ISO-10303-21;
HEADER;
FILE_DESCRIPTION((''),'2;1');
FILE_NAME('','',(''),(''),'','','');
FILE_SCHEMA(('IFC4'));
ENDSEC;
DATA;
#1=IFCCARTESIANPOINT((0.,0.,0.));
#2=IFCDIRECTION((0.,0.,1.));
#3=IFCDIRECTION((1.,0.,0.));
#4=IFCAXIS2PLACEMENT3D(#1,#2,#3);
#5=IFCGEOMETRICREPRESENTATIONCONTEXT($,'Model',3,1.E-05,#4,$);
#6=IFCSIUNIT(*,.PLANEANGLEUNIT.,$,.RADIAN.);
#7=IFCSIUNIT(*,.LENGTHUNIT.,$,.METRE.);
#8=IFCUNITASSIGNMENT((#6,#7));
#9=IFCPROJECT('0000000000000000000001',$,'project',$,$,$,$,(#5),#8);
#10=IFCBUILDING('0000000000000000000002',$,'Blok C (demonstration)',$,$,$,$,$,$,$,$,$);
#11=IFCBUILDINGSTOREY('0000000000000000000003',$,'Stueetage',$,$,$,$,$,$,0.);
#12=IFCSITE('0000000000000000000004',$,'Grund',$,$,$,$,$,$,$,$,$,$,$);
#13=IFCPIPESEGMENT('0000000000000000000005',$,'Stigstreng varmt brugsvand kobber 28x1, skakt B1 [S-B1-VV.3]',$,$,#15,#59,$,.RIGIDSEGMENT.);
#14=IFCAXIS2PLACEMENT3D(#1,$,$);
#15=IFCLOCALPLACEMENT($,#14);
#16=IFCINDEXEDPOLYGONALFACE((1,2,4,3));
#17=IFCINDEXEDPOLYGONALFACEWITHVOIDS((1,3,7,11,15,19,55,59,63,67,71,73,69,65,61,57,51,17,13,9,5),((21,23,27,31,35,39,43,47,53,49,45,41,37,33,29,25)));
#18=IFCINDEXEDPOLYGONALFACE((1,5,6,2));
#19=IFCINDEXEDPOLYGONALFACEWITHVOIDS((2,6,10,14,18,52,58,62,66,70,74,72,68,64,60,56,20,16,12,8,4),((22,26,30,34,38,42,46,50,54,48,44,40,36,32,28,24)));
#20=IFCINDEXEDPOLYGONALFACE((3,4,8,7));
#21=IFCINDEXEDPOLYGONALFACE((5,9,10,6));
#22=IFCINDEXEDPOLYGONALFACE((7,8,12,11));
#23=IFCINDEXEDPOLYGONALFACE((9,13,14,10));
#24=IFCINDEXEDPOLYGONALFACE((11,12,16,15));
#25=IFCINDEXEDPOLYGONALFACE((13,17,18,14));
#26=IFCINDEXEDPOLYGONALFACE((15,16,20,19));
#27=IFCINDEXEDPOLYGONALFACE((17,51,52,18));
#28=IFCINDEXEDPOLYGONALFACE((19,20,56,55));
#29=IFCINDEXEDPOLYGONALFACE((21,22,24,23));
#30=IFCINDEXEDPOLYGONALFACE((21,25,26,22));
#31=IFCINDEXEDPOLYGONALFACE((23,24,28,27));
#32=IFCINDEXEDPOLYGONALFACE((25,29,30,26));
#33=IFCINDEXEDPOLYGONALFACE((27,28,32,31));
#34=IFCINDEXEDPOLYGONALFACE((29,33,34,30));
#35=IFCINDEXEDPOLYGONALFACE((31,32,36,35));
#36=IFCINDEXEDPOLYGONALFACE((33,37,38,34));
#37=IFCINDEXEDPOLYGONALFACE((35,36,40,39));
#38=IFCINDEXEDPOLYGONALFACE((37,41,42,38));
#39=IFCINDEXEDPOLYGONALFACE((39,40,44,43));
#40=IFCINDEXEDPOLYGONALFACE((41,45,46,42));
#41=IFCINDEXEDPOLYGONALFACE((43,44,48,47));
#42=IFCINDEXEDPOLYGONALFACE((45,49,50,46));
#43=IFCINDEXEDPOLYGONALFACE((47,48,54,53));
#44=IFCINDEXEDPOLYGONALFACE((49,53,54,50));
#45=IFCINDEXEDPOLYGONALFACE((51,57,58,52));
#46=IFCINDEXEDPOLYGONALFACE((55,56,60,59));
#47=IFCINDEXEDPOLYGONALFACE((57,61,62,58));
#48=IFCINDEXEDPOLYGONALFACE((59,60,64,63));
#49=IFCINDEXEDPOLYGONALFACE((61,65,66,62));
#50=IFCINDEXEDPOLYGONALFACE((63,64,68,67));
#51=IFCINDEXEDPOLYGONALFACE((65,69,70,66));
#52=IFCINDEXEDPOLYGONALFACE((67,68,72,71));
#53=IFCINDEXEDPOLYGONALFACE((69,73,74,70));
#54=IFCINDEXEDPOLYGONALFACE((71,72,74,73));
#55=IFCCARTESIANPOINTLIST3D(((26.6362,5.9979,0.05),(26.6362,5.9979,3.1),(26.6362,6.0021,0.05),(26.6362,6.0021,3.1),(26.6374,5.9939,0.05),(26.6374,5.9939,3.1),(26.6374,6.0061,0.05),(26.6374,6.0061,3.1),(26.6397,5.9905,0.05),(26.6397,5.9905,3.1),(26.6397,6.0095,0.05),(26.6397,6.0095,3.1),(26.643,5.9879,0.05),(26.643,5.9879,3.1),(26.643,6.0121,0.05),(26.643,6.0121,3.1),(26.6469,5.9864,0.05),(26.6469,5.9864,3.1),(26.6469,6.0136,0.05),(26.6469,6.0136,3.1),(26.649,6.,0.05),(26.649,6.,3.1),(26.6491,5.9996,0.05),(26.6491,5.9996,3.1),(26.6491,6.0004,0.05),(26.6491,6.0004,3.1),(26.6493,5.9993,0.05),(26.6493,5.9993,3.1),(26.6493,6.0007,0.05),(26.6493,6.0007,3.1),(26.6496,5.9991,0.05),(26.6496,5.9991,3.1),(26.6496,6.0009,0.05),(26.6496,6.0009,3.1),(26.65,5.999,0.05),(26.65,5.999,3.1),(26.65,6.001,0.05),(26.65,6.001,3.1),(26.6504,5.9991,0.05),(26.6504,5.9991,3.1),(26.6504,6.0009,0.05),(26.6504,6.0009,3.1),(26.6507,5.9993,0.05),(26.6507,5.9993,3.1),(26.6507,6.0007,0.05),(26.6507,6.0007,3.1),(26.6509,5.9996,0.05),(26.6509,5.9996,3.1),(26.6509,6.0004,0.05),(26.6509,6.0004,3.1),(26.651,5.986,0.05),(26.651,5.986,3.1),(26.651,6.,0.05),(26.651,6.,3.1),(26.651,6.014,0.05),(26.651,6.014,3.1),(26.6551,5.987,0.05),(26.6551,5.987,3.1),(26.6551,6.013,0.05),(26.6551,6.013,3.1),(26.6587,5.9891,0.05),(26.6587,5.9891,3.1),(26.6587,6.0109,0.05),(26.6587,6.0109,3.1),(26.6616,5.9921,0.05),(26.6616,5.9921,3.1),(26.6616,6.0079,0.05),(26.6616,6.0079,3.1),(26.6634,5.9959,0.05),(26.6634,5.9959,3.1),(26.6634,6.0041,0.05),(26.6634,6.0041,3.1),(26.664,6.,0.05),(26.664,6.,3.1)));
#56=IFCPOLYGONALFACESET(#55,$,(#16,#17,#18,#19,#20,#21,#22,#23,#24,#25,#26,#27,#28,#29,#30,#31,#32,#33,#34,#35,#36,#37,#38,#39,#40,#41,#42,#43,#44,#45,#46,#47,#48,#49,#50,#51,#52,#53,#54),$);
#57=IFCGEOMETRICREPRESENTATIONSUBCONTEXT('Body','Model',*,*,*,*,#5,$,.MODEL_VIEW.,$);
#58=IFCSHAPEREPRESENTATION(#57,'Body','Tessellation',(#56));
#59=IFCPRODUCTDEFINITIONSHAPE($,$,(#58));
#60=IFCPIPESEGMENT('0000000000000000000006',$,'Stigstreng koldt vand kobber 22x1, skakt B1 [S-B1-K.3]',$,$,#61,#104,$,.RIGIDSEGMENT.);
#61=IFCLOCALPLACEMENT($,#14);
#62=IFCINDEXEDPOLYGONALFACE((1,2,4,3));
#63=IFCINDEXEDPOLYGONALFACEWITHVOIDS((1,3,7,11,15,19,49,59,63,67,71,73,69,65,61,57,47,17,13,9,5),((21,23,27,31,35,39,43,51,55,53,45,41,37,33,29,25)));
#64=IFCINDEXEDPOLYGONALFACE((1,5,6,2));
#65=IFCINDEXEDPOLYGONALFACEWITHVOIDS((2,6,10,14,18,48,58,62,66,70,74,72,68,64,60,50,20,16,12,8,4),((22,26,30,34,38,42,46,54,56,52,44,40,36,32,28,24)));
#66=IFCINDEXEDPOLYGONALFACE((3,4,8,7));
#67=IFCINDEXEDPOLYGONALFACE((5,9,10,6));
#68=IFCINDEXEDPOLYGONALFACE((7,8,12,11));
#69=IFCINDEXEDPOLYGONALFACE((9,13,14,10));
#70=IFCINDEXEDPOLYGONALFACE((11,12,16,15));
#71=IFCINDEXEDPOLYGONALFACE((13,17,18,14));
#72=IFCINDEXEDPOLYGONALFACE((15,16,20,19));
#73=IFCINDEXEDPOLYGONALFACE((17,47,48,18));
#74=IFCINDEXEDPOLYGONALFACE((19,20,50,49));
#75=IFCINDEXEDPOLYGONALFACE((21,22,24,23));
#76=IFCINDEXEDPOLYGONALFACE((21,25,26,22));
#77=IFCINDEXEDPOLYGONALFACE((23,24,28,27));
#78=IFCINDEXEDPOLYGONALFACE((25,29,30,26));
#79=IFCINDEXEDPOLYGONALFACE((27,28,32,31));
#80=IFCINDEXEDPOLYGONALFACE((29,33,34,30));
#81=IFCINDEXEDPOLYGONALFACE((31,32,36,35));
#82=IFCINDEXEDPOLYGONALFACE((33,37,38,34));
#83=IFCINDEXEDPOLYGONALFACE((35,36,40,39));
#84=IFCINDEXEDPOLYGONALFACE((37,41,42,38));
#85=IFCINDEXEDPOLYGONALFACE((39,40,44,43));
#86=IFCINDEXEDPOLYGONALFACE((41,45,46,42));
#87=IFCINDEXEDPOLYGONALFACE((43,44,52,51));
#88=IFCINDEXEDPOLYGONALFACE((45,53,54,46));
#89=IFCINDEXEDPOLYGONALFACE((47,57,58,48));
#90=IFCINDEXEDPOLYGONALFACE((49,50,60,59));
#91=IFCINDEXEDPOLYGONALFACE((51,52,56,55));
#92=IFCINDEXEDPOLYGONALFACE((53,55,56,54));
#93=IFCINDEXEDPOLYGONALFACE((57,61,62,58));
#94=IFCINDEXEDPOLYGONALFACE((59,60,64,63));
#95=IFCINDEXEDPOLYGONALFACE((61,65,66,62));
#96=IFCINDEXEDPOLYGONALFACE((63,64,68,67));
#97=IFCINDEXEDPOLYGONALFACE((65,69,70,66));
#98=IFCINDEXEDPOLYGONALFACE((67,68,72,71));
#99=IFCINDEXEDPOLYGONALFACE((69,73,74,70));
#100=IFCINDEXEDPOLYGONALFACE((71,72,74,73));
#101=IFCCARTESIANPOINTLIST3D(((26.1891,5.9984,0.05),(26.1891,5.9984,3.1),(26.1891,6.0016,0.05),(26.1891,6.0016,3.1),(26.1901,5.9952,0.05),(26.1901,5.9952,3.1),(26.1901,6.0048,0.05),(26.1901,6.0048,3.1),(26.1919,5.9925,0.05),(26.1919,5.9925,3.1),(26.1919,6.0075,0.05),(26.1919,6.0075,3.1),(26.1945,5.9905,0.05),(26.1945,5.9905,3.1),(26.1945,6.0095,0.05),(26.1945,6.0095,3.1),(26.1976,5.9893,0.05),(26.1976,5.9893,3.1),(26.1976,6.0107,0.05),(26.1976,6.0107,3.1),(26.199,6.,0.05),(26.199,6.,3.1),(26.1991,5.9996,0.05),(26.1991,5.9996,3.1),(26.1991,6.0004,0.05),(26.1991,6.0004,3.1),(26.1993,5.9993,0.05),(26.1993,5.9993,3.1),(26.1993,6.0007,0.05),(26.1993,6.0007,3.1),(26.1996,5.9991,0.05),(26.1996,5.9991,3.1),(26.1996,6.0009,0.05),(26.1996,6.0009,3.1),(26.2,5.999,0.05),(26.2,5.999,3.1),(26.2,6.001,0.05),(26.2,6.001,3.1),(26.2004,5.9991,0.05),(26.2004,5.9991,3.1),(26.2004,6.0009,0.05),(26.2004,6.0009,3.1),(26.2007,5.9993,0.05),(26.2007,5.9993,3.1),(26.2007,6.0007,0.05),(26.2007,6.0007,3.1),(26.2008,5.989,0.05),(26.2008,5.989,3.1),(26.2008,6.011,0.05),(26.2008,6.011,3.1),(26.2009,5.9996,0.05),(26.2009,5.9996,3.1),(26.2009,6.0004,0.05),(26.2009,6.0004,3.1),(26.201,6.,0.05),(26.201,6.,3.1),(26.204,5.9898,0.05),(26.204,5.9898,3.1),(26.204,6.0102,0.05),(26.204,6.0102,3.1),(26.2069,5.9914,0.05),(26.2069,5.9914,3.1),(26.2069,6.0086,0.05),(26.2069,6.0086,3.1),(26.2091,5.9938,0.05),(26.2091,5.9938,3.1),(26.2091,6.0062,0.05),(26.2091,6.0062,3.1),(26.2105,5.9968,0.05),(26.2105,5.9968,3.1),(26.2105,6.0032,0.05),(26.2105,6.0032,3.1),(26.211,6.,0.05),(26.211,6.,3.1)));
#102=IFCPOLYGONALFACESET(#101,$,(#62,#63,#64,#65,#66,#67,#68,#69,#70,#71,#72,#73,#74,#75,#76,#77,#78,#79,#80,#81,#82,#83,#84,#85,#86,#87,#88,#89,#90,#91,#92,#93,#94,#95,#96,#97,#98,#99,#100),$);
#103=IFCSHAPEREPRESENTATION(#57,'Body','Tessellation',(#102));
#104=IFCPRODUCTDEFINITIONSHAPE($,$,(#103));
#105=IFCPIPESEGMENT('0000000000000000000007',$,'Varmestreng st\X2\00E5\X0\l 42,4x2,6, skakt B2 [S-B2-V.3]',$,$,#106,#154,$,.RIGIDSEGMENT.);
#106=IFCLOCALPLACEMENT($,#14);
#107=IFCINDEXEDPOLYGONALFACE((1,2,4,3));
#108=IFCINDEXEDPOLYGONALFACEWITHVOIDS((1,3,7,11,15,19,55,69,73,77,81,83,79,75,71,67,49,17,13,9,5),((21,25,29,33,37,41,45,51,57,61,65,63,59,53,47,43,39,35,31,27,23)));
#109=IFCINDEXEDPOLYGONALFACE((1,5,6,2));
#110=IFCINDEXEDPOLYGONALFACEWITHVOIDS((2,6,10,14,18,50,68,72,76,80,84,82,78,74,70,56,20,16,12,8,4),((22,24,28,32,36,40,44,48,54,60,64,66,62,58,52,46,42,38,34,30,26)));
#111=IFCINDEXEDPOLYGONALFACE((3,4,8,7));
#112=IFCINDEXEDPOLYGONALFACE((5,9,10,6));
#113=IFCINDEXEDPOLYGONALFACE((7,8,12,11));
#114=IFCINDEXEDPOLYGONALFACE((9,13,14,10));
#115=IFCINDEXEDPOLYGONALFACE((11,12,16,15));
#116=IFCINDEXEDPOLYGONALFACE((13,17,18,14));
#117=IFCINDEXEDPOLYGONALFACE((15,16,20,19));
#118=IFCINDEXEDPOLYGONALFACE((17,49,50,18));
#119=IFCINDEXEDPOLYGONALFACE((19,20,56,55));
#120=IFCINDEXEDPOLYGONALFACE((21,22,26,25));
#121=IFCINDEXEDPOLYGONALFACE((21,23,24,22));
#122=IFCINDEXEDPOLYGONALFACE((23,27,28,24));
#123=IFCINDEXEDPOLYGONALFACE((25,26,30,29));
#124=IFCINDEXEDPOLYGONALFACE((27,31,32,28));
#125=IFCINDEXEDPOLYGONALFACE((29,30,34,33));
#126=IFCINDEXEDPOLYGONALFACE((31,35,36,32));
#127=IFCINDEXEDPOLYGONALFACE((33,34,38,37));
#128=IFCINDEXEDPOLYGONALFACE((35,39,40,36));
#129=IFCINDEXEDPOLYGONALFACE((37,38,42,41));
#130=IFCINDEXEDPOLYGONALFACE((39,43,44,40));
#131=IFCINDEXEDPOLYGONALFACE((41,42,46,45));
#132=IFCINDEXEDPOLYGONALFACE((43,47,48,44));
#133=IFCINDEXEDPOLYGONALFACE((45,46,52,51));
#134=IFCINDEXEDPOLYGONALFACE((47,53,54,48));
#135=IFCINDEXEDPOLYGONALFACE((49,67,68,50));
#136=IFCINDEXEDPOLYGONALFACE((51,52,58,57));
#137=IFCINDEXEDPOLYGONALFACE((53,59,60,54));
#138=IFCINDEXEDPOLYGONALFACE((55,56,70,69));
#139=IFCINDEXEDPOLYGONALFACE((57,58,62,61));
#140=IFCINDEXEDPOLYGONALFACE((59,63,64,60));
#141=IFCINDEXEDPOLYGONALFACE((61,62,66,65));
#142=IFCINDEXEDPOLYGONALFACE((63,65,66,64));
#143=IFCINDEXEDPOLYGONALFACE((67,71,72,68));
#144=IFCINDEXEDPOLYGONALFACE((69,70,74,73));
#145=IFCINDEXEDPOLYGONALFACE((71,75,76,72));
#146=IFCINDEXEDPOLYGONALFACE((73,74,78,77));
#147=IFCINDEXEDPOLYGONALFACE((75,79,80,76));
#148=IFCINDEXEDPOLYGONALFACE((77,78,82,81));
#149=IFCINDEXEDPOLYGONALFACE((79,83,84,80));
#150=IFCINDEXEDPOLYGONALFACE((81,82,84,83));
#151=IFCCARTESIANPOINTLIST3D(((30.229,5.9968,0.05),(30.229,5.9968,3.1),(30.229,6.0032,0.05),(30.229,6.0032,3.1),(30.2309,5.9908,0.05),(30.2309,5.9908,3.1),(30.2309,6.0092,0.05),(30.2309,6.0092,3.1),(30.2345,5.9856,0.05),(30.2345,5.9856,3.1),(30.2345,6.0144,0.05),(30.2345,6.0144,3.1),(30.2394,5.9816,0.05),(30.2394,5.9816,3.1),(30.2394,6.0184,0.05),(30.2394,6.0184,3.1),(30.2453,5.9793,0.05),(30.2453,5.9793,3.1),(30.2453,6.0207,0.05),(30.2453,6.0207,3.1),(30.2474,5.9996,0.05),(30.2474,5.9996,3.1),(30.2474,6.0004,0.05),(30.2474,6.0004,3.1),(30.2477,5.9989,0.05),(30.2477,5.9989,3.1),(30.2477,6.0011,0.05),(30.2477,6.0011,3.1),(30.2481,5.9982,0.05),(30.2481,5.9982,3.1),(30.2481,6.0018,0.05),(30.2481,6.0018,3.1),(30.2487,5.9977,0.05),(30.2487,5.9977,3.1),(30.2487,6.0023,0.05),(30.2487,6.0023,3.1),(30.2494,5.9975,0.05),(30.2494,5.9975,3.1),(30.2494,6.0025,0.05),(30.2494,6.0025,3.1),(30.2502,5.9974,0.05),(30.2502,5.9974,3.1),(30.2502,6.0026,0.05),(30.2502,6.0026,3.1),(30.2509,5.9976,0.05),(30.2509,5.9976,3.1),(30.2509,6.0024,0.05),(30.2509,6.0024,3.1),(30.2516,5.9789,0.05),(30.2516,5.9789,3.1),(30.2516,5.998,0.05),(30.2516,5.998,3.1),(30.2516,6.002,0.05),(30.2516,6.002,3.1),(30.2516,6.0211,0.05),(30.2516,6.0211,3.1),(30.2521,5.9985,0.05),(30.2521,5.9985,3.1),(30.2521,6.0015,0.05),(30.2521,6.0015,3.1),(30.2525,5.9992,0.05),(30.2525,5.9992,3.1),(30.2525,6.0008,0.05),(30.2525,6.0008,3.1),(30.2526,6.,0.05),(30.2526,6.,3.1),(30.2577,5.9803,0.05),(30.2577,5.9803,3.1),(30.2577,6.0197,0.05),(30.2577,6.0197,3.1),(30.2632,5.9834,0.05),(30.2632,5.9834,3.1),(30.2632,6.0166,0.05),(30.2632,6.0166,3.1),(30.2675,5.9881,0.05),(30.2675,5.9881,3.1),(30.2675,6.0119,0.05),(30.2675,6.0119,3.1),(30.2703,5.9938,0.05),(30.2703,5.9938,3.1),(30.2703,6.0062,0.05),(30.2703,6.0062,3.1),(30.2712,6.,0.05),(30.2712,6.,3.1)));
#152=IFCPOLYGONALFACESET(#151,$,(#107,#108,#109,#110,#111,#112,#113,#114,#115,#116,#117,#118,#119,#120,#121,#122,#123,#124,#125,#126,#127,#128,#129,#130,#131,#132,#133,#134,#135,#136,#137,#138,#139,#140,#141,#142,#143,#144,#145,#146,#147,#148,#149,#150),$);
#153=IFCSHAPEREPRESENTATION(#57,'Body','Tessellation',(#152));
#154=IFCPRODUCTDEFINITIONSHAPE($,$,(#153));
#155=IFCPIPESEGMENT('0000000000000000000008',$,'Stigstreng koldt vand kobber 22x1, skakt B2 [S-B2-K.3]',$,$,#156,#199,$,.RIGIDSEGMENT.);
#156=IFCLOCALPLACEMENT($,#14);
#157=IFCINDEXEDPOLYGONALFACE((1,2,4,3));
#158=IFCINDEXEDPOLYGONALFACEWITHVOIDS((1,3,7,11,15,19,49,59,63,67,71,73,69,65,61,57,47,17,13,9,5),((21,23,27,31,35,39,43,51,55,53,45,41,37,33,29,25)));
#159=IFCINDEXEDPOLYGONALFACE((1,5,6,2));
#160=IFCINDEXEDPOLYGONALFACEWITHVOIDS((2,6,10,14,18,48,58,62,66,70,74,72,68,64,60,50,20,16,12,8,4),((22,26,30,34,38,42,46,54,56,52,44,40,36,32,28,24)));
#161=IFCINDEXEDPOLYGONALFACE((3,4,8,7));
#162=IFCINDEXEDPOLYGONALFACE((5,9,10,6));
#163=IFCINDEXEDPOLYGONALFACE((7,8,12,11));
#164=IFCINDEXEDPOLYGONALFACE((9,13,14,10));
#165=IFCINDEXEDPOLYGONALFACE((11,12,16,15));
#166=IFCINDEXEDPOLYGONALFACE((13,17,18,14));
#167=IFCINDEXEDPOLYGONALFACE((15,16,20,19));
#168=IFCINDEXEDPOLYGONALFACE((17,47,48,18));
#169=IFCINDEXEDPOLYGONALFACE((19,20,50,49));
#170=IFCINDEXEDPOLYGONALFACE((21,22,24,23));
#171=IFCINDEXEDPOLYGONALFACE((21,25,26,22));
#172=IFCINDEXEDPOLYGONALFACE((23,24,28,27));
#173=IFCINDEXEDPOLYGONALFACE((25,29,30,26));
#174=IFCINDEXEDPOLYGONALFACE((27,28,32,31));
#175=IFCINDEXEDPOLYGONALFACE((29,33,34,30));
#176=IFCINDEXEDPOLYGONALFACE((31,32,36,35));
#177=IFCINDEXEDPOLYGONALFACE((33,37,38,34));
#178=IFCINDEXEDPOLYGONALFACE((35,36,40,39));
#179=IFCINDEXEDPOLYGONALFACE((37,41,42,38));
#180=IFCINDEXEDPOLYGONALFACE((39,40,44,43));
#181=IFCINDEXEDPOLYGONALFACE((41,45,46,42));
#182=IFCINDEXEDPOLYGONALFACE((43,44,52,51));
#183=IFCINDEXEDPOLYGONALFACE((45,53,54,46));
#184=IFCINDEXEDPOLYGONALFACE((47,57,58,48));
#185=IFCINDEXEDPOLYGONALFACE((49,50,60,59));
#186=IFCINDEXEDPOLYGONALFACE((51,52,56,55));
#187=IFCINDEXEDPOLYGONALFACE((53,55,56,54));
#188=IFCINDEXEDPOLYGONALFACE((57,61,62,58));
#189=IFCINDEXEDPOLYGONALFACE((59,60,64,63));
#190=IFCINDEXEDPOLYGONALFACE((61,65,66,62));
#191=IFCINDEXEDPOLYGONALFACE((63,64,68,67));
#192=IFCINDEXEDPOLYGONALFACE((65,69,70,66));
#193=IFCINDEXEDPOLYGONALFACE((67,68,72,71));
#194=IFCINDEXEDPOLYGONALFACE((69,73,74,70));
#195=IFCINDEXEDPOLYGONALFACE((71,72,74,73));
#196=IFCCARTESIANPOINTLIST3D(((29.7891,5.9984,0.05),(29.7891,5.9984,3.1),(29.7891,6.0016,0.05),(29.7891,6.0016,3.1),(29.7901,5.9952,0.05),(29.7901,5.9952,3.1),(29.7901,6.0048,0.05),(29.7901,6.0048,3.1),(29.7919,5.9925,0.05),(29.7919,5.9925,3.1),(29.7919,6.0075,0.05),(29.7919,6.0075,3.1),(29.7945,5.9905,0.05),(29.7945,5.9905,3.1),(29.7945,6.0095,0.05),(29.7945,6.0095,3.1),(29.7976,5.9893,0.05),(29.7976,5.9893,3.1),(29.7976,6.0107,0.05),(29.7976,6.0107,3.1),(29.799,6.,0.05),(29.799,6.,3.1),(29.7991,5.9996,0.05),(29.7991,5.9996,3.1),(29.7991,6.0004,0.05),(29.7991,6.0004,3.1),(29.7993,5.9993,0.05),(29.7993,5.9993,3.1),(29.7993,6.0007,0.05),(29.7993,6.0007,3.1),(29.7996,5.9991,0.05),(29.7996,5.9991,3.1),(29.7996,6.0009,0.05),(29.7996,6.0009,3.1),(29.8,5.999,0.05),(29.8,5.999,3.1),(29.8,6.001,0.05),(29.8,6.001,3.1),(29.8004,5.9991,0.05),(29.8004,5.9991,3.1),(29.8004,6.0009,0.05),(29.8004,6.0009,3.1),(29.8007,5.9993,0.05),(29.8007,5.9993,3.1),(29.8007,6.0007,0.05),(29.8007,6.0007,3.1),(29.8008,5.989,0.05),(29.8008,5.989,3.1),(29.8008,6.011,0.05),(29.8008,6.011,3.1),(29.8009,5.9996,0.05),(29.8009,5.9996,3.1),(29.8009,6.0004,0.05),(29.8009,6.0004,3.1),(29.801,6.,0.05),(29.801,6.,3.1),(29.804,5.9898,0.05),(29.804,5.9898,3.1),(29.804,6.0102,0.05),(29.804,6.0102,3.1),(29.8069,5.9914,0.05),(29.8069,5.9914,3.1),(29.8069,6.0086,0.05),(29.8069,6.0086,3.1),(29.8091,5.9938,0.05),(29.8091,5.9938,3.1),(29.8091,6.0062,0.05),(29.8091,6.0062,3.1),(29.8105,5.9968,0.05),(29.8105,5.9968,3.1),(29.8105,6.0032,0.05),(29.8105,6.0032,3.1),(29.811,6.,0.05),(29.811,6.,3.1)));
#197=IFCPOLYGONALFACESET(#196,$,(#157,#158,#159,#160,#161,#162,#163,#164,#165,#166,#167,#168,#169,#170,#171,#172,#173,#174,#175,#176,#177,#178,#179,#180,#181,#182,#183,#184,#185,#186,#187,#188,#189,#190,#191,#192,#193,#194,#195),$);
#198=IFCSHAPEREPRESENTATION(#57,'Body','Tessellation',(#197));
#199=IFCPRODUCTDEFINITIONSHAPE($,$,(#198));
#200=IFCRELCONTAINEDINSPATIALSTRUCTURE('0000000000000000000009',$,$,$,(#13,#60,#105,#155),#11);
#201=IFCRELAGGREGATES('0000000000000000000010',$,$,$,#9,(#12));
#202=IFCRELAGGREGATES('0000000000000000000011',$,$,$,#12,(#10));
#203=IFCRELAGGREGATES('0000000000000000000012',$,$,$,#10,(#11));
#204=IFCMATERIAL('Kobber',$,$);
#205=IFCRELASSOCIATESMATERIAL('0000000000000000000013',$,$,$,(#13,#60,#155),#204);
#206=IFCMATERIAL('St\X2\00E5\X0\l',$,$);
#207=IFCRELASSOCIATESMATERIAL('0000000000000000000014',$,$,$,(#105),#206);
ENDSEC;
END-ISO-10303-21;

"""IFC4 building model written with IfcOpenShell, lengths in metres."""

from ifc_helpers import new_model, si_unit, frame, origin_with_axes, place, context, subcontext, project, spatial, hollow_circle, extrude, material, element, save


model = new_model("IFC4")

# Units and contexts
model_context = context("Model", 3, precision=1e-05, world=origin_with_axes())
body_context = subcontext(model_context, "Body", "Model", "MODEL_VIEW")
ifc_project = project(units=[si_unit("PLANEANGLEUNIT", "RADIAN"), si_unit("LENGTHUNIT", "METRE")], contexts=[model_context])

# Site, building, storey
site = spatial("IfcSite", under=ifc_project, Name="Grund")
building = spatial("IfcBuilding", under=site, Name="Blok C (demonstration)")
storey = spatial("IfcBuildingStorey", under=building, Name="Stueetage", Elevation=0.0)

# Pipe segments
ifc_material_1 = material(Name="Stål")
ifc_material_2 = material(Name="Kobber")
pipe_segment_1_placement = place(None, origin_with_axes())
element("IfcPipeSegment", 1, at=pipe_segment_1_placement, inside=storey, material=ifc_material_2, Name="Stigstreng varmt brugsvand kobber 28x1, skakt B1 [S-B1-VV.3]", PredefinedType="RIGIDSEGMENT", context=body_context, shape_type="SweptSolid", body=[
    extrude(hollow_circle(Radius=0.014, WallThickness=0.013), frame((26.65, 6.0, 0.05), z_axis=(0.0, 0.0, 1.0), x_axis=(1.0, 0.0, 0.0)), (0.0, 0.0, 1.0), 3.05),
])
pipe_segment_2_placement = place(None, origin_with_axes())
element("IfcPipeSegment", 2, at=pipe_segment_2_placement, inside=storey, material=ifc_material_2, Name="Stigstreng koldt vand kobber 22x1, skakt B1 [S-B1-K.3]", PredefinedType="RIGIDSEGMENT", context=body_context, shape_type="SweptSolid", body=[
    extrude(hollow_circle(Radius=0.011, WallThickness=0.01), frame((26.2, 6.0, 0.05), z_axis=(0.0, 0.0, 1.0), x_axis=(1.0, 0.0, 0.0)), (0.0, 0.0, 1.0), 3.05),
])
pipe_segment_3_placement = place(None, origin_with_axes())
element("IfcPipeSegment", 3, at=pipe_segment_3_placement, inside=storey, material=ifc_material_1, Name="Varmestreng stål 42,4x2,6, skakt B2 [S-B2-V.3]", PredefinedType="RIGIDSEGMENT", context=body_context, shape_type="SweptSolid", body=[
    extrude(hollow_circle(Radius=0.0212, WallThickness=0.0186), frame((30.25, 6.0, 0.05), z_axis=(0.0, 0.0, 1.0), x_axis=(1.0, 0.0, 0.0)), (0.0, 0.0, 1.0), 3.05),
])
pipe_segment_4_placement = place(None, origin_with_axes())
element("IfcPipeSegment", 4, at=pipe_segment_4_placement, inside=storey, material=ifc_material_2, Name="Stigstreng koldt vand kobber 22x1, skakt B2 [S-B2-K.3]", PredefinedType="RIGIDSEGMENT", context=body_context, shape_type="SweptSolid", body=[
    extrude(hollow_circle(Radius=0.011, WallThickness=0.01), frame((29.8, 6.0, 0.05), z_axis=(0.0, 0.0, 1.0), x_axis=(1.0, 0.0, 0.0)), (0.0, 0.0, 1.0), 3.05),
])

save(model, "model.ifc")
